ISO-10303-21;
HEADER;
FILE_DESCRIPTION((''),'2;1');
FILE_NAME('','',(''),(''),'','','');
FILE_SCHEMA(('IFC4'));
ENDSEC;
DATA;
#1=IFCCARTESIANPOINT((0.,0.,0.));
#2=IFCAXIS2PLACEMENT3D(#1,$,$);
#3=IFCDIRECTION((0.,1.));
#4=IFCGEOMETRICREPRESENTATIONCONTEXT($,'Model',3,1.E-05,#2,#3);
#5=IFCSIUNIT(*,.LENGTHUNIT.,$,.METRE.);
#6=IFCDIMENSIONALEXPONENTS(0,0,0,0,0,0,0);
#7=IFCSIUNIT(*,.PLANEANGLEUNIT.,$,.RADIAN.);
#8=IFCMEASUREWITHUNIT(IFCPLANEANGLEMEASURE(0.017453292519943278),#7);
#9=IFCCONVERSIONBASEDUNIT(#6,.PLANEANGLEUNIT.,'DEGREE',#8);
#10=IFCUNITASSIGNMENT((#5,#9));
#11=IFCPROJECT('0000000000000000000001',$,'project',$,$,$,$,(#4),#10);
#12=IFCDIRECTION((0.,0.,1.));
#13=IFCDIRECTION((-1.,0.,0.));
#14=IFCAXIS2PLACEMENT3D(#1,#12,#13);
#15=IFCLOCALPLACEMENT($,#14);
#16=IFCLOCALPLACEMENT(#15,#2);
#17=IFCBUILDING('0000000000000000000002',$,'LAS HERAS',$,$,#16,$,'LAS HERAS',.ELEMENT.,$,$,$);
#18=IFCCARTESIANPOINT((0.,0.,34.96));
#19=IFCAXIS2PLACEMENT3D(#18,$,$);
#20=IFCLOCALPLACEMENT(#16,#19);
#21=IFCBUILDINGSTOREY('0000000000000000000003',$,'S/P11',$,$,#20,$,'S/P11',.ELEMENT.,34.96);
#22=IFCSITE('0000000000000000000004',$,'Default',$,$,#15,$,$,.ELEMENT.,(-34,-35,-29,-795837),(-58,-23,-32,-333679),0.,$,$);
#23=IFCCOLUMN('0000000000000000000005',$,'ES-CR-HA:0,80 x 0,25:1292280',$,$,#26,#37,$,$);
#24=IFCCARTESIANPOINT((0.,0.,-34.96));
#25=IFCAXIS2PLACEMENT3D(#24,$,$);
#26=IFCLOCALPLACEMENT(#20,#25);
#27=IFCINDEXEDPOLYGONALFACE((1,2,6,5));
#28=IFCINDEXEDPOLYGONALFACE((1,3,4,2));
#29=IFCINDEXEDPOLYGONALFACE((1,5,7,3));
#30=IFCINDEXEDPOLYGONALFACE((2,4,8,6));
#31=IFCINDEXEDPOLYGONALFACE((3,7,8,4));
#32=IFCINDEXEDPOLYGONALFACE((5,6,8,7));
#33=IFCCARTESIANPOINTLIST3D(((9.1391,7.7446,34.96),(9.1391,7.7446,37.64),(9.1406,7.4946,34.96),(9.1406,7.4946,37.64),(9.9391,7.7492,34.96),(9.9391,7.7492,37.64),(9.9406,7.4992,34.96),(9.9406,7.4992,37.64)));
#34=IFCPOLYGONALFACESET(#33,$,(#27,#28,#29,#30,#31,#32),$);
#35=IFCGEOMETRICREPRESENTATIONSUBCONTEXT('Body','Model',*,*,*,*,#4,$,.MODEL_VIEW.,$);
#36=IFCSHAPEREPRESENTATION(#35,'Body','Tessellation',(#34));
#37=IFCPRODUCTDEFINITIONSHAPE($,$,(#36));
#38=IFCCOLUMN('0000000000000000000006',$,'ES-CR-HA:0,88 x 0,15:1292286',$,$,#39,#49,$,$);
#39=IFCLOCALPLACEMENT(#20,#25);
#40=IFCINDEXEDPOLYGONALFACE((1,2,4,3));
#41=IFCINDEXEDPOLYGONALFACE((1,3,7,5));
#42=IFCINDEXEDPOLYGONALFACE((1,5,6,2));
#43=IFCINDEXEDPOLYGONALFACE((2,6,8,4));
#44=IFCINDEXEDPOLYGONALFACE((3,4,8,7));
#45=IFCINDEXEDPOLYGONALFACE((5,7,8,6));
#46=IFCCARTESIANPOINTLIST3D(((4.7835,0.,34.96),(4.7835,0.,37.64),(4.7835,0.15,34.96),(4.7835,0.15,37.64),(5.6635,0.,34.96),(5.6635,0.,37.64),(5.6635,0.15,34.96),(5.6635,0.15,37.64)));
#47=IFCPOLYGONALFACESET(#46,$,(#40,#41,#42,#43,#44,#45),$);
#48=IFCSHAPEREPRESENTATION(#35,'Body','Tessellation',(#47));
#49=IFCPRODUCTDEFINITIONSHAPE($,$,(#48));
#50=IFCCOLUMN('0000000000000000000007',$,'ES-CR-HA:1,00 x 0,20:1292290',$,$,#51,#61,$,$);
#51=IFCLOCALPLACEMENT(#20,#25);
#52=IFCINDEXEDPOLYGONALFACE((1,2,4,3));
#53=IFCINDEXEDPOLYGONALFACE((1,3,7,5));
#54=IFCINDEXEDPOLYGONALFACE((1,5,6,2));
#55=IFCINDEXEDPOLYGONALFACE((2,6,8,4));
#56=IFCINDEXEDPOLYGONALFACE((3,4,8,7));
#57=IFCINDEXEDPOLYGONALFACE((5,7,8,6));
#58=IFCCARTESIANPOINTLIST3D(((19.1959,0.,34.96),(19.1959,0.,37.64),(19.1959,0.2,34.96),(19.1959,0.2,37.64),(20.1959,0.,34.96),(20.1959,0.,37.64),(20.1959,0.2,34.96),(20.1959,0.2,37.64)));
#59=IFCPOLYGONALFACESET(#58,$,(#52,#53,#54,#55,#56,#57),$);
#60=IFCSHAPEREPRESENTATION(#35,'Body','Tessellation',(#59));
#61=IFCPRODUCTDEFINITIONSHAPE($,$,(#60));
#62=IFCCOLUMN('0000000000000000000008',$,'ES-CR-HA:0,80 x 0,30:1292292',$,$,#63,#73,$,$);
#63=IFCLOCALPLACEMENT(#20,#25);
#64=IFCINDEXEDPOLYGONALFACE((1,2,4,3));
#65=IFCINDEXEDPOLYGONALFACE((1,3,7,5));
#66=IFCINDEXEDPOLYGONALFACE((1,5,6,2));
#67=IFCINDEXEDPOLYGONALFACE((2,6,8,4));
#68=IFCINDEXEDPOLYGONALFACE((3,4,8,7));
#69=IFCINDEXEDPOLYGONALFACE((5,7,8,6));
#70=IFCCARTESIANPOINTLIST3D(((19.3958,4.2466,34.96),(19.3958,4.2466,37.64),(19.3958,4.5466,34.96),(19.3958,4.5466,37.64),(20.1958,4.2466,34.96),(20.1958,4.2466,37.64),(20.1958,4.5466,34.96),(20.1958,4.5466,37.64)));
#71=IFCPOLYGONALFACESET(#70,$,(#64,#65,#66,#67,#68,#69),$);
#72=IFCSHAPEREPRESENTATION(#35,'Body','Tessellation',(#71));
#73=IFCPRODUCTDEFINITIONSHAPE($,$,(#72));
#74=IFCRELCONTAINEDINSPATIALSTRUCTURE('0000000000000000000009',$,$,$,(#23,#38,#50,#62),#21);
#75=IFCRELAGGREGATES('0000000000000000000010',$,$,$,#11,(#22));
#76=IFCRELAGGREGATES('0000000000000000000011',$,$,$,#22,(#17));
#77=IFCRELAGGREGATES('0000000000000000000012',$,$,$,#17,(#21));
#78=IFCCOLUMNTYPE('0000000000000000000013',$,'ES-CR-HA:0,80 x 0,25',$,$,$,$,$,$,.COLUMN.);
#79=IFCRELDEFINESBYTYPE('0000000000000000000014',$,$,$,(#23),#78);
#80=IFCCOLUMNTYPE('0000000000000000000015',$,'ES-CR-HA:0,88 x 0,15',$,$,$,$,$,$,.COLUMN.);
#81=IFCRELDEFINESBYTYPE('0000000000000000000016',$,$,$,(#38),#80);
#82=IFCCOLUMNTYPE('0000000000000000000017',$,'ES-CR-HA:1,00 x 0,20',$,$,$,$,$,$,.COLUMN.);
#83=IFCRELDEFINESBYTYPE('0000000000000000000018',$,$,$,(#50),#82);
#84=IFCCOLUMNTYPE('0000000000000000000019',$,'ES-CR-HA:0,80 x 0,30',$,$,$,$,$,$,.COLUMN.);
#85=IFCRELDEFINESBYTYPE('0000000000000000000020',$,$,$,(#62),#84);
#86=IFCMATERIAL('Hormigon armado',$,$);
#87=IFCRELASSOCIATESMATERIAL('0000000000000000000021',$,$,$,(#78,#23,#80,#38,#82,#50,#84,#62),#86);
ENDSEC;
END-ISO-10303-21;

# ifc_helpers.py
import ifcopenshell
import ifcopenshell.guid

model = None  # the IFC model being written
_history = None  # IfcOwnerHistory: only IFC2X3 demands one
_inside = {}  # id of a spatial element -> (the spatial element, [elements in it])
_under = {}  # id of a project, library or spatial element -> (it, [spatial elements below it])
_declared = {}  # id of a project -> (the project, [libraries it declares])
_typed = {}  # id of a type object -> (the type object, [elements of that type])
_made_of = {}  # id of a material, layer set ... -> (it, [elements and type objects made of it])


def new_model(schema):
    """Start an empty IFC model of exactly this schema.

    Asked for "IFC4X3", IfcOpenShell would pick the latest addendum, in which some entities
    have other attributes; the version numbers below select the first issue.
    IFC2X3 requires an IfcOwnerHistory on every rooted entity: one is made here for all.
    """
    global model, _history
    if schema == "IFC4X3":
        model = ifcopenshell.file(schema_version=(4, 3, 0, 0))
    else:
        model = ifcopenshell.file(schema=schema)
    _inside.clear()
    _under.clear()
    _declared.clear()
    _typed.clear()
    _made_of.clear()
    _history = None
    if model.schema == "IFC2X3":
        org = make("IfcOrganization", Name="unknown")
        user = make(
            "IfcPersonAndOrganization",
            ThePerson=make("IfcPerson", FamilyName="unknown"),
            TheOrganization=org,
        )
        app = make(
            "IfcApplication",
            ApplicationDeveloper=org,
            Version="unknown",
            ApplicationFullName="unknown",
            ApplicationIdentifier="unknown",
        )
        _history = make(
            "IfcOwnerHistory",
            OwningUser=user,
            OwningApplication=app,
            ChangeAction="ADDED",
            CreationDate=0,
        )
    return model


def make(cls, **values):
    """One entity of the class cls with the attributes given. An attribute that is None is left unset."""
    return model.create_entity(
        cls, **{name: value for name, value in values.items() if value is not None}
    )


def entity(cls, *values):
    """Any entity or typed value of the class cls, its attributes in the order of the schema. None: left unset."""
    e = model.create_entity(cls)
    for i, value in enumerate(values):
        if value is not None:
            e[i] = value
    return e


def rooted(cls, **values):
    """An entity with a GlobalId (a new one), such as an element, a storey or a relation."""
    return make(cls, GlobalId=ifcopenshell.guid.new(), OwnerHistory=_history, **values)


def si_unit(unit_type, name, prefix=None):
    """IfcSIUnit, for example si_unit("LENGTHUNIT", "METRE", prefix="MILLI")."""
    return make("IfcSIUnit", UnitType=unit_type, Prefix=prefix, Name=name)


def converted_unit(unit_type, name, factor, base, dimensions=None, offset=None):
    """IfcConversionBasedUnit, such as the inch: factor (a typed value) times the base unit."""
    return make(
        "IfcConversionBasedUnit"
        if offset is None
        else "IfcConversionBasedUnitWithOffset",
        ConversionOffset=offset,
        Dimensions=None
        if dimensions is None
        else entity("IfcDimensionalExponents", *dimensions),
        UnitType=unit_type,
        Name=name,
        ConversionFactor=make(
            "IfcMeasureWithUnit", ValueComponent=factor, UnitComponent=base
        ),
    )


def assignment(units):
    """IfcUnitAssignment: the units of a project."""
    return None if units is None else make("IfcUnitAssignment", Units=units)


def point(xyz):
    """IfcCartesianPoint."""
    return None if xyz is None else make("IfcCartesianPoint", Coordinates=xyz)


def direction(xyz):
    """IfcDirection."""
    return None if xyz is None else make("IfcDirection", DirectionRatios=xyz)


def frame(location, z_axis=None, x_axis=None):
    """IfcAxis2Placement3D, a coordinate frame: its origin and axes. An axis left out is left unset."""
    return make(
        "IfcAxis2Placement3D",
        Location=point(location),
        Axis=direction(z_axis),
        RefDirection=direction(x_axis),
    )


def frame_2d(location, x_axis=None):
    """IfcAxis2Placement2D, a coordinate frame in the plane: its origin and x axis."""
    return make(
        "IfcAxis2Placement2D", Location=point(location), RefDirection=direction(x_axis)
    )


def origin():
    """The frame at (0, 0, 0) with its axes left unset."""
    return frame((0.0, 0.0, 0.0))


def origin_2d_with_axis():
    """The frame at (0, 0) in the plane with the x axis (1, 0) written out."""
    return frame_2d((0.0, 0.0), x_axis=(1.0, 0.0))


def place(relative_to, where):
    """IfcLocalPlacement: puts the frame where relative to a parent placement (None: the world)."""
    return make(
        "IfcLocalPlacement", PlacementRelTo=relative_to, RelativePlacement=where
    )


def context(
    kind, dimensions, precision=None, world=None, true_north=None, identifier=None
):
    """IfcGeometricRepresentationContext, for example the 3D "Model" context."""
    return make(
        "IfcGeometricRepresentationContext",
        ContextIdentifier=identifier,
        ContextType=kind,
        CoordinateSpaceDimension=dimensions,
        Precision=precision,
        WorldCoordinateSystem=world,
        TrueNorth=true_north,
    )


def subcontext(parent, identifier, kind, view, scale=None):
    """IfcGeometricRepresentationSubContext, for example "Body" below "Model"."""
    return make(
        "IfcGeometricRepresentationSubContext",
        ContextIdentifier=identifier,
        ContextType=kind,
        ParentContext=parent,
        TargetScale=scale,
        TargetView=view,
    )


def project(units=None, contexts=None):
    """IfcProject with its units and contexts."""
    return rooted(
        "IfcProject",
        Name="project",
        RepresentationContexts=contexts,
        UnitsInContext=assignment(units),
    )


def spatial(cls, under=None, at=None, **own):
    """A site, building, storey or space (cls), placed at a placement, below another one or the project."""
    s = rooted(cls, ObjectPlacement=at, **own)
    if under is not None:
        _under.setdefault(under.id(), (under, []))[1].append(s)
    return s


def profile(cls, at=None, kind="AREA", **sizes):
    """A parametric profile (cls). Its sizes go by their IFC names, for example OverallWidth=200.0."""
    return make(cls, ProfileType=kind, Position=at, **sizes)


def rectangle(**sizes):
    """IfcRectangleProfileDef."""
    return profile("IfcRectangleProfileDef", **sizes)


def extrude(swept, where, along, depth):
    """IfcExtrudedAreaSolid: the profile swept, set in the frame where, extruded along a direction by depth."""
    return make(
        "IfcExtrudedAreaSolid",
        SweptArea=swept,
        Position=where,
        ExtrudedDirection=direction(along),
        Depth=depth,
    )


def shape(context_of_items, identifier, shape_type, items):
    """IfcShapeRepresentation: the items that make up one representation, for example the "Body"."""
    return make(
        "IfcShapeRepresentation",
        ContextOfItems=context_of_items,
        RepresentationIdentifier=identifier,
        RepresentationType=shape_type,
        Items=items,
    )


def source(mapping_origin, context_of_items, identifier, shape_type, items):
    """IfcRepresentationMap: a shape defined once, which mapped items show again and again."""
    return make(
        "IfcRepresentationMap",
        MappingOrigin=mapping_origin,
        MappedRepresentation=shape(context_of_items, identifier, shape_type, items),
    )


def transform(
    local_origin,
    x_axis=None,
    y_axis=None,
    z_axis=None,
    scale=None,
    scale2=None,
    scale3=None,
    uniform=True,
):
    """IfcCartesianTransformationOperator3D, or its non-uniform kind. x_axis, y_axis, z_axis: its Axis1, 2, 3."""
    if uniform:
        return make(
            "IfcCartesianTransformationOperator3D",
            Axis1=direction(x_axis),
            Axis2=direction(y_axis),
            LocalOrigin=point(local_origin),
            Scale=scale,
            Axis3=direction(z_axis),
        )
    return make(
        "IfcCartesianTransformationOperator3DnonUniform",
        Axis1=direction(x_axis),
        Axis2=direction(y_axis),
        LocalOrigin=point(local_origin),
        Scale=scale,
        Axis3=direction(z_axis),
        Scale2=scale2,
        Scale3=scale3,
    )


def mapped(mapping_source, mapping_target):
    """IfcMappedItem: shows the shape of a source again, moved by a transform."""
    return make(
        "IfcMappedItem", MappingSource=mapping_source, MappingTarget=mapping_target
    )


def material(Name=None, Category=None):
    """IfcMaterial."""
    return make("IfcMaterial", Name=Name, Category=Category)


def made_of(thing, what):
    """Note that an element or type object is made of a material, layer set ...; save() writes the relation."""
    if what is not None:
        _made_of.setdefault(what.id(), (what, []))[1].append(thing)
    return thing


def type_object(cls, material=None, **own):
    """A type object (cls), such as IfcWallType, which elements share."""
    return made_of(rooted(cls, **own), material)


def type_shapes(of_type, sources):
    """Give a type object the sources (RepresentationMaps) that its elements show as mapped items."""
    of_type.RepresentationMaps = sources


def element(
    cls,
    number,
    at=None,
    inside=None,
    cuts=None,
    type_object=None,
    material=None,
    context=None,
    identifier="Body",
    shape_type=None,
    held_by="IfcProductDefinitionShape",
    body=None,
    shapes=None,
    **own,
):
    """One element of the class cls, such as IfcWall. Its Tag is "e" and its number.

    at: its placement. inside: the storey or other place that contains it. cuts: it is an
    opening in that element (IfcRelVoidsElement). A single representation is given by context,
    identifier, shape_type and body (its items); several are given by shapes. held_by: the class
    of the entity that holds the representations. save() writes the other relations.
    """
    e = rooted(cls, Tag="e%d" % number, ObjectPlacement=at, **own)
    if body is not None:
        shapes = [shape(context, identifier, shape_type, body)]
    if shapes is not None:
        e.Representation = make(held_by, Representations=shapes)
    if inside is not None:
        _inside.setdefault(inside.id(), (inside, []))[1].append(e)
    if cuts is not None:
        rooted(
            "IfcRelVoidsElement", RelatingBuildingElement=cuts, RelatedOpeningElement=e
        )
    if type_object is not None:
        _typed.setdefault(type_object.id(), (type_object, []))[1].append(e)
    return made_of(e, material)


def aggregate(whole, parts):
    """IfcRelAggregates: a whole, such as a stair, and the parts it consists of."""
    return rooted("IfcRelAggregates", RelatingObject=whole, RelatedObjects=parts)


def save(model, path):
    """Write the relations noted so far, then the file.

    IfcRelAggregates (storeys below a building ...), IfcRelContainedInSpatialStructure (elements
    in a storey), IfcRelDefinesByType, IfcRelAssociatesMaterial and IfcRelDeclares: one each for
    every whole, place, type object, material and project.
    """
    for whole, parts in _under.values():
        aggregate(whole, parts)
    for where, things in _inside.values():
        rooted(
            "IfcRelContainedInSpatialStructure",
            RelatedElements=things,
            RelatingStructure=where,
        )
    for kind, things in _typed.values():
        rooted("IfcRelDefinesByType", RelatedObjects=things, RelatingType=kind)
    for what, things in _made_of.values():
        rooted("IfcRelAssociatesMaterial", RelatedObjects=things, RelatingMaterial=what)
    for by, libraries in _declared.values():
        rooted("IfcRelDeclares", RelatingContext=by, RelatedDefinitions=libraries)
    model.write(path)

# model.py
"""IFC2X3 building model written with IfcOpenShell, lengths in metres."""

from ifc_helpers import new_model, entity, si_unit, converted_unit, direction, frame, frame_2d, origin, origin_2d_with_axis, place, context, subcontext, project, spatial, rectangle, extrude, source, transform, mapped, material, type_object, type_shapes, element, save


model = new_model("IFC2X3")

# Units and contexts
model_context = context("Model", 3, precision=1e-05, world=origin(), true_north=direction((0.0, 1.0)))
body_context = subcontext(model_context, "Body", "Model", "MODEL_VIEW")
ifc_project = project(units=[si_unit("LENGTHUNIT", "METRE"), converted_unit("PLANEANGLEUNIT", "DEGREE", entity("IfcPlaneAngleMeasure", 0.017453292519943278), si_unit("PLANEANGLEUNIT", "RADIAN"), dimensions=[0, 0, 0, 0, 0, 0, 0])], contexts=[model_context])

# Site, building, storey
site_placement = place(None, frame((0.0, 0.0, 0.0), z_axis=(0.0, 0.0, 1.0), x_axis=(-1.0, 0.0, 0.0)))
site = spatial("IfcSite", under=ifc_project, at=site_placement, Name="Default", CompositionType="ELEMENT", RefLatitude=(-34, -35, -29, -795837), RefLongitude=(-58, -23, -32, -333679), RefElevation=0.0)
building_placement = place(site_placement, origin())
building = spatial("IfcBuilding", under=site, at=building_placement, Name="LAS HERAS", LongName="LAS HERAS", CompositionType="ELEMENT")
storey_placement = place(building_placement, frame((0.0, 0.0, 34.96)))
storey = spatial("IfcBuildingStorey", under=building, at=storey_placement, Name="S/P11", LongName="S/P11", CompositionType="ELEMENT", Elevation=34.96)

# Columns
ifc_material = material(Name="Hormigon armado")
column_type_1 = type_object("IfcColumnType", Name="ES-CR-HA:0,80 x 0,25", PredefinedType="COLUMN", material=ifc_material)
shared_shape_1 = source(origin(), body_context, "Body", "SweptSolid", [
    extrude(rectangle(XDim=2.68, YDim=0.25, at=frame_2d((0.0, -0.0034), x_axis=(1.0, 0.0))), frame((9.1399, 7.6162, 36.3), z_axis=(0.999983, 0.005788, 0.0), x_axis=(0.0, 0.0, 1.0)), (0.0, 0.0, 1.0), 0.8),
])
type_shapes(column_type_1, [shared_shape_1])
column_1_placement = place(storey_placement, frame((0.0, 0.0, -34.96)))
element("IfcColumn", 1, at=column_1_placement, inside=storey, type_object=column_type_1, material=ifc_material, Name="ES-CR-HA:0,80 x 0,25:1292280", context=body_context, shape_type="MappedRepresentation", body=[
    mapped(shared_shape_1, transform((0.0, 0.0, 0.0), scale=1.0)),
])
column_type_2 = type_object("IfcColumnType", Name="ES-CR-HA:0,88 x 0,15", PredefinedType="COLUMN", material=ifc_material)
shared_shape_2 = source(origin(), body_context, "Body", "SweptSolid", [
    extrude(rectangle(XDim=2.68, YDim=0.15, at=frame_2d((0.0, 0.0), x_axis=(1.0, 0.0))), frame((4.7835, 0.075, 36.3), z_axis=(1.0, 0.0, 0.0), x_axis=(0.0, 0.0, 1.0)), (0.0, 0.0, 1.0), 0.88),
])
type_shapes(column_type_2, [shared_shape_2])
column_2_placement = place(storey_placement, frame((0.0, 0.0, -34.96)))
element("IfcColumn", 2, at=column_2_placement, inside=storey, type_object=column_type_2, material=ifc_material, Name="ES-CR-HA:0,88 x 0,15:1292286", context=body_context, shape_type="MappedRepresentation", body=[
    mapped(shared_shape_2, transform((0.0, 0.0, 0.0), scale=1.0)),
])
column_type_3 = type_object("IfcColumnType", Name="ES-CR-HA:1,00 x 0,20", PredefinedType="COLUMN", material=ifc_material)
shared_shape_3 = source(origin(), body_context, "Body", "SweptSolid", [
    extrude(rectangle(XDim=1.0, YDim=0.2, at=origin_2d_with_axis()), frame((19.6959, 0.1, 34.96), z_axis=(0.0, 0.0, 1.0), x_axis=(-1.0, 0.0, 0.0)), (0.0, 0.0, 1.0), 2.68),
])
type_shapes(column_type_3, [shared_shape_3])
column_3_placement = place(storey_placement, frame((0.0, 0.0, -34.96)))
element("IfcColumn", 3, at=column_3_placement, inside=storey, type_object=column_type_3, material=ifc_material, Name="ES-CR-HA:1,00 x 0,20:1292290", context=body_context, shape_type="MappedRepresentation", body=[
    mapped(shared_shape_3, transform((0.0, 0.0, 0.0), scale=1.0)),
])
column_type_4 = type_object("IfcColumnType", Name="ES-CR-HA:0,80 x 0,30", PredefinedType="COLUMN", material=ifc_material)
shared_shape_4 = source(origin(), body_context, "Body", "SweptSolid", [
    extrude(rectangle(XDim=0.8, YDim=0.3, at=frame_2d((0.0, 0.0), x_axis=(1.0, 0.0))), frame((19.7958, 4.3966, 34.96), z_axis=(0.0, 0.0, 1.0), x_axis=(-1.0, 0.0, 0.0)), (0.0, 0.0, 1.0), 2.68),
])
type_shapes(column_type_4, [shared_shape_4])
column_4_placement = place(storey_placement, frame((0.0, 0.0, -34.96)))
element("IfcColumn", 4, at=column_4_placement, inside=storey, type_object=column_type_4, material=ifc_material, Name="ES-CR-HA:0,80 x 0,30:1292292", context=body_context, shape_type="MappedRepresentation", body=[
    mapped(shared_shape_4, transform((0.0, 0.0, 0.0), scale=1.0)),
])

save(model, "model.ifc")
